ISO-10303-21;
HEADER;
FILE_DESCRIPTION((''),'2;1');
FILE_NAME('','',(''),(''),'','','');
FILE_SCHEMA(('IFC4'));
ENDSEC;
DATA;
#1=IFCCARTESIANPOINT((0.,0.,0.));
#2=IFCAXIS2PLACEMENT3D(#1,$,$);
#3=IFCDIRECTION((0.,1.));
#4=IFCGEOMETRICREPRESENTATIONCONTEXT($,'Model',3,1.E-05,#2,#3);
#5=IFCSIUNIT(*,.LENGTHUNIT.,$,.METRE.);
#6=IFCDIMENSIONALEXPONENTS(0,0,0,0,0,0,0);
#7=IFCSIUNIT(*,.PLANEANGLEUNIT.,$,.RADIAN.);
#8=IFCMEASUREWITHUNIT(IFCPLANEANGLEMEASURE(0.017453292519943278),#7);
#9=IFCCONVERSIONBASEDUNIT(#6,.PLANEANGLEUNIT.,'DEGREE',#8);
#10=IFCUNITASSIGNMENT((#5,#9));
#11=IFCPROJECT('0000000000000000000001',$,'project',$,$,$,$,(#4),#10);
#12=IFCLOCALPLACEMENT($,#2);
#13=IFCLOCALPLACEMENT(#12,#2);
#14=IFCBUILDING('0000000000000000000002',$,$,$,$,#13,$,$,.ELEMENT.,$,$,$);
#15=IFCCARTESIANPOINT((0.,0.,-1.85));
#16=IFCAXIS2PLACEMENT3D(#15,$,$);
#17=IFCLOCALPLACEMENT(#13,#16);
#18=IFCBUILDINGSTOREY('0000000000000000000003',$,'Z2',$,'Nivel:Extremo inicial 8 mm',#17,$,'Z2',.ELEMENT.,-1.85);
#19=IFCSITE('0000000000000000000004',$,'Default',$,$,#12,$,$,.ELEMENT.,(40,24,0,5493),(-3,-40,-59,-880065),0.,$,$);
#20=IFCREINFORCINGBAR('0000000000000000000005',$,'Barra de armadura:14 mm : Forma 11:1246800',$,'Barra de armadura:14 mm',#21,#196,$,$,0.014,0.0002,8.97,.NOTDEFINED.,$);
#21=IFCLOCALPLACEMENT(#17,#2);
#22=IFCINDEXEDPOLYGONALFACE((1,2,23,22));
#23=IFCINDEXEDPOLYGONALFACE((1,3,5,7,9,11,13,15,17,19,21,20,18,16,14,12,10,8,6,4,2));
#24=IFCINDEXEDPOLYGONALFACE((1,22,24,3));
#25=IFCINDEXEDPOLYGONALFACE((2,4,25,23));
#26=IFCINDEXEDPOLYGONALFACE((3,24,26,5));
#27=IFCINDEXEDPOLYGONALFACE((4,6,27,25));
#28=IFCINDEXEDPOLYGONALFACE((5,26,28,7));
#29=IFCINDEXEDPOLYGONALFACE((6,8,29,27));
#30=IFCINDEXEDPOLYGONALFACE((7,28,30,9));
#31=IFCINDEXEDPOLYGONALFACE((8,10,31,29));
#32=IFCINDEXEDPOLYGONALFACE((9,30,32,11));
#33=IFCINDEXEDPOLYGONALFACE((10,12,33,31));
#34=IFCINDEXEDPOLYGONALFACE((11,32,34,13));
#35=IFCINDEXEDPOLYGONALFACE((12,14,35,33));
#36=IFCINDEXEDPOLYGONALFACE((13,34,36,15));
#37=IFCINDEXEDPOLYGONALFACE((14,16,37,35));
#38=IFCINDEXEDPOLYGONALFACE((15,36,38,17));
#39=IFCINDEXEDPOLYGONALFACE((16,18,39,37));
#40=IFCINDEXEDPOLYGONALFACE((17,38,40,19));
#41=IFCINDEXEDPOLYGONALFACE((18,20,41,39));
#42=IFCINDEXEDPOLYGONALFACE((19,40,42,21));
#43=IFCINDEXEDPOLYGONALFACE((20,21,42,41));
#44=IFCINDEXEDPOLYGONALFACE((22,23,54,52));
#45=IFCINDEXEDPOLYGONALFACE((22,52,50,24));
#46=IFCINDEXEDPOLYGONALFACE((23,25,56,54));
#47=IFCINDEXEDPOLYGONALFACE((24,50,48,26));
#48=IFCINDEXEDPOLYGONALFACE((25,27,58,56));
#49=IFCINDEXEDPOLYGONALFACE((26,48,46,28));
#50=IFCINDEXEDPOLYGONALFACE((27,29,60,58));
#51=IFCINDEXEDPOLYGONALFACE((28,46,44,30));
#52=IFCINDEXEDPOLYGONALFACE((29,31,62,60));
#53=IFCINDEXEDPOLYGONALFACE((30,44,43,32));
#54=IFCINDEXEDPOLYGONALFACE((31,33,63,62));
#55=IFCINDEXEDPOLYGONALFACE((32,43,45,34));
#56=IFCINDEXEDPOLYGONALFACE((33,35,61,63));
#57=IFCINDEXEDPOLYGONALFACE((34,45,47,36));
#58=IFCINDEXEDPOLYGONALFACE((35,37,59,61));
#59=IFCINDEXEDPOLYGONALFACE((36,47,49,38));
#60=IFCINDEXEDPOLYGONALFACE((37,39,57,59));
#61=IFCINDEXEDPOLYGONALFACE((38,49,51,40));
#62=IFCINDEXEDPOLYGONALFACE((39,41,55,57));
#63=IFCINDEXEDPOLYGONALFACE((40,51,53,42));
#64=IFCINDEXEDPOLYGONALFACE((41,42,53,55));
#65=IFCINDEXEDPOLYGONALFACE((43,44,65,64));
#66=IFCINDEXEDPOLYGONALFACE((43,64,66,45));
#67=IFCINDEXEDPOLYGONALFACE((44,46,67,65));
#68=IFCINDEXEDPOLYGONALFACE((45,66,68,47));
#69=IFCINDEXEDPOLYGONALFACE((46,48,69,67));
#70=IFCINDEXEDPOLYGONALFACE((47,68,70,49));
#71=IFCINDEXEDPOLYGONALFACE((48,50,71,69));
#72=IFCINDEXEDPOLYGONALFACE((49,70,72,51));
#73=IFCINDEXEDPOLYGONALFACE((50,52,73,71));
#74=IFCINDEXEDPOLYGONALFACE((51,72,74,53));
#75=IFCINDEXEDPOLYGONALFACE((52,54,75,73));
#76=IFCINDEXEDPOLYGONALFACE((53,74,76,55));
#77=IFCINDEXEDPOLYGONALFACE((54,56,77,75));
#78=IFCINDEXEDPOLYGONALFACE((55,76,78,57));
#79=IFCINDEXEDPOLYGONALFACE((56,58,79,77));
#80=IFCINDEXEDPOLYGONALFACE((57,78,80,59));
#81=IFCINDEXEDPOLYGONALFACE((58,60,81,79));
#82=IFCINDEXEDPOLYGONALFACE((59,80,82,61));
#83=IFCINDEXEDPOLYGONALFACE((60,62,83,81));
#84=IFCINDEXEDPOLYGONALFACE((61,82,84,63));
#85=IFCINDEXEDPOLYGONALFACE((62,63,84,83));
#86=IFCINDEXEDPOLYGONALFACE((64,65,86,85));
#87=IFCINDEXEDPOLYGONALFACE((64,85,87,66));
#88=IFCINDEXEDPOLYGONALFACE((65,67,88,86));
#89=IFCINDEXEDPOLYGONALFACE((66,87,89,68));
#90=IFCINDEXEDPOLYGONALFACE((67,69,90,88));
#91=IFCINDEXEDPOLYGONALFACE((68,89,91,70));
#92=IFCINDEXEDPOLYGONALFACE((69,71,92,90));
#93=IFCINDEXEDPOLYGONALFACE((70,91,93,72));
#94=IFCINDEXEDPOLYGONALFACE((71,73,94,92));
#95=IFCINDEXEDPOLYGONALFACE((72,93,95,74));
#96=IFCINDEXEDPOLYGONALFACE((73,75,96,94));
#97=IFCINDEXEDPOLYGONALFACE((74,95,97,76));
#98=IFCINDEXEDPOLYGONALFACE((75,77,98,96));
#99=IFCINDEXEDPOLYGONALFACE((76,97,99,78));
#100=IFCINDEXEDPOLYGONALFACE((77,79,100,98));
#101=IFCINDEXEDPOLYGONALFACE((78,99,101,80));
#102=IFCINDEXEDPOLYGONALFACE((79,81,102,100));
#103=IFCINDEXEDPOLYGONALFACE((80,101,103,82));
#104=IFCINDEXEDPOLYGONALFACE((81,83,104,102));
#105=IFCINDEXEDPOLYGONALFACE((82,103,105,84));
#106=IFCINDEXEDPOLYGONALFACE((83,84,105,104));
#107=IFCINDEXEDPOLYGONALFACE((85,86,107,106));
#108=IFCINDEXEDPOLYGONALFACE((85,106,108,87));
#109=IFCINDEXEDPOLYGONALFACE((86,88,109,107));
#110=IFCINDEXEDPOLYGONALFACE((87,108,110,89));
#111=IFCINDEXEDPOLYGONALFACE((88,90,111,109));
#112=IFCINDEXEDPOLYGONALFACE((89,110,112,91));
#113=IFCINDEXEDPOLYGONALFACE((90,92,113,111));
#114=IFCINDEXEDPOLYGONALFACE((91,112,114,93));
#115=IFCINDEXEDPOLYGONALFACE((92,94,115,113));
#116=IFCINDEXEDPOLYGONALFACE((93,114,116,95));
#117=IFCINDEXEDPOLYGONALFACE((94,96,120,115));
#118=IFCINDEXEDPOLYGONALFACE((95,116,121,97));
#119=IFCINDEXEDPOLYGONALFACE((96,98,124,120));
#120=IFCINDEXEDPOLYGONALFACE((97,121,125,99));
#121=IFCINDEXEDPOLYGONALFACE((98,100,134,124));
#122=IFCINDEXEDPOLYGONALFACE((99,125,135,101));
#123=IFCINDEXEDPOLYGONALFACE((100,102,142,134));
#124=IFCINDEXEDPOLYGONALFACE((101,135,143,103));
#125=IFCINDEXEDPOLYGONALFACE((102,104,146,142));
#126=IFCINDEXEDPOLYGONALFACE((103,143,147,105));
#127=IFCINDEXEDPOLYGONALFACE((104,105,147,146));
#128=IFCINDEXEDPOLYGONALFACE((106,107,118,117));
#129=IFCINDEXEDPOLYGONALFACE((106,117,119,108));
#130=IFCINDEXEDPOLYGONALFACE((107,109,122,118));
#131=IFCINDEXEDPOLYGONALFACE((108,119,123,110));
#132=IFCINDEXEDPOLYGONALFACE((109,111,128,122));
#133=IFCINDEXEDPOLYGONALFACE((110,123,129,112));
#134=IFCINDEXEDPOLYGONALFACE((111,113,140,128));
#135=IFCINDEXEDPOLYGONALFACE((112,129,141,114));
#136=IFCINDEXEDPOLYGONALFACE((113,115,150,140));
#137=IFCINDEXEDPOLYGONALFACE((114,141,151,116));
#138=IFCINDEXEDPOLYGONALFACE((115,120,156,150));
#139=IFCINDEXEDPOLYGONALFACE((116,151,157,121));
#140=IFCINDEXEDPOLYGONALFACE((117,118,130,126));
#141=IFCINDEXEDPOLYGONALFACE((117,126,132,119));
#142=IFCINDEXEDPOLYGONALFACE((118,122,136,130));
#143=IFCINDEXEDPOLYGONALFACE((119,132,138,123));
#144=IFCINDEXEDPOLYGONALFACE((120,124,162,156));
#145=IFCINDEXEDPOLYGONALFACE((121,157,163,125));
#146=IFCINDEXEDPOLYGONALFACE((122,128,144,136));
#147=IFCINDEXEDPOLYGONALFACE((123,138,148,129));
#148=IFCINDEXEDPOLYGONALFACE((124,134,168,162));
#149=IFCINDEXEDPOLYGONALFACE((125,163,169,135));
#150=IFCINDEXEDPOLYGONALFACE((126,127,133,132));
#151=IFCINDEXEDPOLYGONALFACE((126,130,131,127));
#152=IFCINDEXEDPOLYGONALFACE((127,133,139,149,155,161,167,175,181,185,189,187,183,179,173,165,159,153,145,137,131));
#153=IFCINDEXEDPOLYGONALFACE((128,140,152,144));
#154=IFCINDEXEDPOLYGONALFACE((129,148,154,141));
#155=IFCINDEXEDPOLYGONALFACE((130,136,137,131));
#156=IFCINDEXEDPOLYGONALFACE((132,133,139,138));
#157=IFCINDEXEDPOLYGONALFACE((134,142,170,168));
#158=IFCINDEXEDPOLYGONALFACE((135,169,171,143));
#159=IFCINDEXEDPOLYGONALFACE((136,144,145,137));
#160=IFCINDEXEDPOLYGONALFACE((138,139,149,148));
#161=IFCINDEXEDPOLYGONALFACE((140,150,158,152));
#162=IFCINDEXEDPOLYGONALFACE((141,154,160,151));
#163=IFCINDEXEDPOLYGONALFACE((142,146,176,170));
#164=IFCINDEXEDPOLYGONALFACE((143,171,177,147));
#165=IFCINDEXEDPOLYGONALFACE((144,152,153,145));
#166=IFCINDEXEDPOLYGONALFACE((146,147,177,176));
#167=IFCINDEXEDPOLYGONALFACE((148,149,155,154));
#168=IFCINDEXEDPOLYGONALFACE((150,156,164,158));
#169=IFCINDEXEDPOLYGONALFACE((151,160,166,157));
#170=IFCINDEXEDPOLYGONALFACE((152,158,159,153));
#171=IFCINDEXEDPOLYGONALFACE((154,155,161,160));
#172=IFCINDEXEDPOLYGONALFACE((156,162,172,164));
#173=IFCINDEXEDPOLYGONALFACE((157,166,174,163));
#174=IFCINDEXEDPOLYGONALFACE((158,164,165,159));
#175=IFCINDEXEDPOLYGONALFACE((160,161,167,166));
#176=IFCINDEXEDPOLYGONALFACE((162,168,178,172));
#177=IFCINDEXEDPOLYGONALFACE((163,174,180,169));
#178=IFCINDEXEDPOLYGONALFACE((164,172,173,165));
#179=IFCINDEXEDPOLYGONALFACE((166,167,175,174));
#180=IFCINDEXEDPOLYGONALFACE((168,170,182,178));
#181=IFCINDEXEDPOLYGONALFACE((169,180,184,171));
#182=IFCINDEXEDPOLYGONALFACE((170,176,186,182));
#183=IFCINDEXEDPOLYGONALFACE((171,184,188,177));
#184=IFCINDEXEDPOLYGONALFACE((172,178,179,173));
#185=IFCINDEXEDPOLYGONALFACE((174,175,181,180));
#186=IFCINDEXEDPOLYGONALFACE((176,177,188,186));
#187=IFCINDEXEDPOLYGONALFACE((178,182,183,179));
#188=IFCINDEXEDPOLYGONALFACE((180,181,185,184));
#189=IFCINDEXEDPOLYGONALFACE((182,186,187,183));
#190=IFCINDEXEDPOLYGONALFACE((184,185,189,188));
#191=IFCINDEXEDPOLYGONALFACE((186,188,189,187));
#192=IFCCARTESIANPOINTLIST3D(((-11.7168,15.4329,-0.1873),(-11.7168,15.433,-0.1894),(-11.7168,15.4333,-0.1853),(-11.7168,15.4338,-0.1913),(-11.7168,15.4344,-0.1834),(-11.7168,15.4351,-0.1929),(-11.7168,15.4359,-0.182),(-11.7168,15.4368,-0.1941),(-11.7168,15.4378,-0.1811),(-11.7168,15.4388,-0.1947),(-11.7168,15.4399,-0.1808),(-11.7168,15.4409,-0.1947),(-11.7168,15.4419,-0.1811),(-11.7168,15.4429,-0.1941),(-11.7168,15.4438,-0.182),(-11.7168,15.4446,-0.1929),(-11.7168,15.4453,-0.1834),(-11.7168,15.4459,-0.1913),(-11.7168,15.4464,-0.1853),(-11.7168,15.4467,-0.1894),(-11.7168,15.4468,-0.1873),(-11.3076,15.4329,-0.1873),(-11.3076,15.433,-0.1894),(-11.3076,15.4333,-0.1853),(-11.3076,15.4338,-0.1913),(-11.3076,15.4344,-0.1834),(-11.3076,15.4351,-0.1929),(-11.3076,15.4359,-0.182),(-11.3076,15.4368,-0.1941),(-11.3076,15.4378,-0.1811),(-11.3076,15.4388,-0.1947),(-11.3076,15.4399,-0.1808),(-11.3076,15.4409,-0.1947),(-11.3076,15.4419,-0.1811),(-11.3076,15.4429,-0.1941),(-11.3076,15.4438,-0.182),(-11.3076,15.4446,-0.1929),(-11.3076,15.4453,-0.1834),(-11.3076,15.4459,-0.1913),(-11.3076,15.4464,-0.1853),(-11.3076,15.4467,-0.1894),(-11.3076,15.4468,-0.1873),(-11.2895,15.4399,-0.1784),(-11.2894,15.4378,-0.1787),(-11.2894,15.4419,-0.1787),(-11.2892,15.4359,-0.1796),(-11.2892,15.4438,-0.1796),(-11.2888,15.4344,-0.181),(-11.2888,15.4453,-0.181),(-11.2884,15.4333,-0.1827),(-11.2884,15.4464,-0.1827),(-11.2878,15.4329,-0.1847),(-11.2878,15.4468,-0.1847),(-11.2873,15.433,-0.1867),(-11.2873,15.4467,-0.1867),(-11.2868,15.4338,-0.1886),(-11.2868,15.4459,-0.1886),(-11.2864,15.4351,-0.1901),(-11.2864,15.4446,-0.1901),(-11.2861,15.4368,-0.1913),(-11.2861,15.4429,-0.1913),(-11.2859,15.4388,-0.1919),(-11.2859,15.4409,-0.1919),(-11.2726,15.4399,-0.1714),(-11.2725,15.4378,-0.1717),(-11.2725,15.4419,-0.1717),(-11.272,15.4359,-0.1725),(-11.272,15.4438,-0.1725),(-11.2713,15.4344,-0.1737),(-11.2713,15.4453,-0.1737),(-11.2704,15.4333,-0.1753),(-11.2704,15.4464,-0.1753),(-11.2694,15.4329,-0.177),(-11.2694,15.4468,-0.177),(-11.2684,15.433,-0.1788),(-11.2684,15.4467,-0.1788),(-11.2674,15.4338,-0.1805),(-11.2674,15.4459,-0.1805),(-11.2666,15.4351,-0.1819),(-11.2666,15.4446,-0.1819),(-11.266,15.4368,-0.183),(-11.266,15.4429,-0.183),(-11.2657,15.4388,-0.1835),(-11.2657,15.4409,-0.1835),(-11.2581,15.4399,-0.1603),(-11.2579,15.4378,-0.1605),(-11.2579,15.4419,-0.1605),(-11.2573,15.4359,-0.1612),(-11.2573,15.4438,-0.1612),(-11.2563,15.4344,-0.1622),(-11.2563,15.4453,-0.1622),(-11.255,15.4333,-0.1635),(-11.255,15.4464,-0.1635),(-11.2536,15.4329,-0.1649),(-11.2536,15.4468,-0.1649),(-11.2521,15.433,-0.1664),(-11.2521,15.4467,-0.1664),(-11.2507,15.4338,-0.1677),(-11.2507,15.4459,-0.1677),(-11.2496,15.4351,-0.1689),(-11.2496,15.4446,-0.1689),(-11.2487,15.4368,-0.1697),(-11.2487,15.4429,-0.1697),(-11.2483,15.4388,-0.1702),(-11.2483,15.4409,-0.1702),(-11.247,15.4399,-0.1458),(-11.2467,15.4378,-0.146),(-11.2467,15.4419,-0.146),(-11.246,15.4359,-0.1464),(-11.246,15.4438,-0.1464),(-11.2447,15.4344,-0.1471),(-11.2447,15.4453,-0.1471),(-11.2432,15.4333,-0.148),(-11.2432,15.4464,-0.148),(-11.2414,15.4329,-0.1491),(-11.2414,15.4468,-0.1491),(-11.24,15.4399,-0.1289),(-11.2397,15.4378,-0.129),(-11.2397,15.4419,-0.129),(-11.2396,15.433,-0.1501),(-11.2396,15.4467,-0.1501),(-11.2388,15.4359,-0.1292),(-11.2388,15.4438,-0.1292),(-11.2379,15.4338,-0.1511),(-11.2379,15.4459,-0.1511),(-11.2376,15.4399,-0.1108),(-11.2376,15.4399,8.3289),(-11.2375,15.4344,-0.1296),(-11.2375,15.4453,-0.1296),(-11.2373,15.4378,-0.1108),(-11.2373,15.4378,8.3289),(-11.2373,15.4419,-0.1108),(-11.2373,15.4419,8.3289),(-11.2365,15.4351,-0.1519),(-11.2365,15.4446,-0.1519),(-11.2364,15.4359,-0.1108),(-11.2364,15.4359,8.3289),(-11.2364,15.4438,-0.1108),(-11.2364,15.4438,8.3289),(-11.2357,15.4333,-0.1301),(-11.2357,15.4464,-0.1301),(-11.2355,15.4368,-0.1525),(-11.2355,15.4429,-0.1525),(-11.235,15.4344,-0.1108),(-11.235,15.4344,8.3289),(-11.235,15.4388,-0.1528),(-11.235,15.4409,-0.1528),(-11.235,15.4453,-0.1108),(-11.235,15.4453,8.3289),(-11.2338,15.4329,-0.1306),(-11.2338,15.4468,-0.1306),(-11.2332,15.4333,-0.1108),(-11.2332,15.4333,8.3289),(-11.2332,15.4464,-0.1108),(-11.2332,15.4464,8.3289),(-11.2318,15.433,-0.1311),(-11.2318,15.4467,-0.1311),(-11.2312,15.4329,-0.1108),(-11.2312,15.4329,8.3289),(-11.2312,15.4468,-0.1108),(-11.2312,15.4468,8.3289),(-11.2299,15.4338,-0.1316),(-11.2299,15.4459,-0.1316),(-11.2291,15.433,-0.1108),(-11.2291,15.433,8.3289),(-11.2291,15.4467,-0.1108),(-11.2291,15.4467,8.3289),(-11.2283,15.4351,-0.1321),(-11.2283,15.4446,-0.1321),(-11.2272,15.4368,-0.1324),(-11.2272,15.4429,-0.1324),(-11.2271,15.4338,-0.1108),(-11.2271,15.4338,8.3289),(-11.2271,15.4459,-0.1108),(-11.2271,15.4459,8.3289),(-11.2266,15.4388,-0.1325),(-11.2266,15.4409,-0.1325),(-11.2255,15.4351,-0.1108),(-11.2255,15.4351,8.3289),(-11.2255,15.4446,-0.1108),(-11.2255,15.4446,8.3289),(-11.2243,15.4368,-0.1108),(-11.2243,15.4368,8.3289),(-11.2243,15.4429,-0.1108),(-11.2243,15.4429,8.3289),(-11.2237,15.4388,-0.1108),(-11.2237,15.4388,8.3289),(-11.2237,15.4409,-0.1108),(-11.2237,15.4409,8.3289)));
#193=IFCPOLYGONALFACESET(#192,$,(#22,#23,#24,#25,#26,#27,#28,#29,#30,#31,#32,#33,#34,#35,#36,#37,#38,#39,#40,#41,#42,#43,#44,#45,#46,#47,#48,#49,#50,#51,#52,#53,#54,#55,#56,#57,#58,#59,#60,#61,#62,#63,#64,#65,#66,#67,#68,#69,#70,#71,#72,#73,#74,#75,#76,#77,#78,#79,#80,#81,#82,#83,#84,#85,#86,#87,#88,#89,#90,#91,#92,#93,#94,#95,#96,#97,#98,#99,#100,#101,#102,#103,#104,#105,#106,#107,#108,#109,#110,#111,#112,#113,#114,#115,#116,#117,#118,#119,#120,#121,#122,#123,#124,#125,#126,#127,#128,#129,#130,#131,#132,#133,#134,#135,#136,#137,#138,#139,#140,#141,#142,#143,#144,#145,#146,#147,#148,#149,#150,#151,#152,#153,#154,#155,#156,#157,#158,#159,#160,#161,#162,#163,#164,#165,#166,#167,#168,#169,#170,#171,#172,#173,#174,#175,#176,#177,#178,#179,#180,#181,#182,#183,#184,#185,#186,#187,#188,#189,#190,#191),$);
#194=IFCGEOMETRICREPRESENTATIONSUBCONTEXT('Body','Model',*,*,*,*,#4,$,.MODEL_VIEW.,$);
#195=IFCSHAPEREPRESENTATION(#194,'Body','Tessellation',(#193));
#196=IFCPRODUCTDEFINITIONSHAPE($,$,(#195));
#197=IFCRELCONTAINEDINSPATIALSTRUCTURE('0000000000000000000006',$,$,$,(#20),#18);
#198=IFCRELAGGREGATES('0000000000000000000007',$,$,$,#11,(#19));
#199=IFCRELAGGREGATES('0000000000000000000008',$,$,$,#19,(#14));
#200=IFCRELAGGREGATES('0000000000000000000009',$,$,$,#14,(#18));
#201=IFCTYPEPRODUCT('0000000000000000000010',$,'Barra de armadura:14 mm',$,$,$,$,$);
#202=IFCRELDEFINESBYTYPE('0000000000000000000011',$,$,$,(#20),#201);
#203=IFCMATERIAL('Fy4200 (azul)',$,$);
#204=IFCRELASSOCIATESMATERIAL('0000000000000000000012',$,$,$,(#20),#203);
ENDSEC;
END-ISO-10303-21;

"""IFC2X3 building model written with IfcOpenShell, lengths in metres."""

from ifc_helpers import new_model, entity, si_unit, converted_unit, direction, frame, origin, place, context, subcontext, project, spatial, material, type_object, element, save


model = new_model("IFC2X3")

# Units and contexts
model_context = context("Model", 3, precision=1e-05, world=origin(), true_north=direction((0.0, 1.0)))
body_context = subcontext(model_context, "Body", "Model", "MODEL_VIEW")
ifc_project = project(units=[si_unit("LENGTHUNIT", "METRE"), converted_unit("PLANEANGLEUNIT", "DEGREE", entity("IfcPlaneAngleMeasure", 0.017453292519943278), si_unit("PLANEANGLEUNIT", "RADIAN"), dimensions=[0, 0, 0, 0, 0, 0, 0])], contexts=[model_context])

# Site, building, storey
site_placement = place(None, origin())
site = spatial("IfcSite", under=ifc_project, at=site_placement, Name="Default", CompositionType="ELEMENT", RefLatitude=(40, 24, 0, 5493), RefLongitude=(-3, -40, -59, -880065), RefElevation=0.0)
building_placement = place(site_placement, origin())
building = spatial("IfcBuilding", under=site, at=building_placement, CompositionType="ELEMENT")
storey_placement = place(building_placement, frame((0.0, 0.0, -1.85)))
storey = spatial("IfcBuildingStorey", under=building, at=storey_placement, Name="Z2", ObjectType="Nivel:Extremo inicial 8 mm", LongName="Z2", CompositionType="ELEMENT", Elevation=-1.85)

# Reinforcing bar
ifc_material_1 = material(Name="Fy4200 (azul)")
type_product_1 = type_object("IfcTypeProduct", Name="Barra de armadura:14 mm")
reinforcing_bar_1_placement = place(storey_placement, origin())
element("IfcReinforcingBar", 1, at=reinforcing_bar_1_placement, inside=storey, type_object=type_product_1, material=ifc_material_1, Name="Barra de armadura:14 mm : Forma 11:1246800", ObjectType="Barra de armadura:14 mm", BarLength=8.97, BarRole="NOTDEFINED", CrossSectionArea=0.0002, NominalDiameter=0.014, context=body_context, shape_type="AdvancedSweptSolid", body=[
    entity("IfcSweptDiskSolid", entity("IfcCompositeCurve", [entity("IfcCompositeCurveSegment", "CONTINUOUS", True, entity("IfcPolyline", [entity("IfcCartesianPoint", [-11.2306, 15.4399, 8.3289]), entity("IfcCartesianPoint", [-11.2306, 15.4399, -0.1108])])), entity("IfcCompositeCurveSegment", "CONTINUOUS", True, entity("IfcTrimmedCurve", entity("IfcCircle", entity("IfcAxis2Placement3D", entity("IfcCartesianPoint", [-11.3076, 15.4399, -0.1108]), entity("IfcDirection", [0.0, 1.0, 0.0]), entity("IfcDirection", [0.0, 0.0, -1.0])), 0.077), [entity("IfcParameterValue", 270.0)], [entity("IfcParameterValue", 360.0)], True, "PARAMETER")), entity("IfcCompositeCurveSegment", "CONTINUOUS", True, entity("IfcPolyline", [entity("IfcCartesianPoint", [-11.3076, 15.4399, -0.1878]), entity("IfcCartesianPoint", [-11.7168, 15.4399, -0.1878])]))], False), 0.007, None, 0.0, 92.0),
])

save(model, "model.ifc")
